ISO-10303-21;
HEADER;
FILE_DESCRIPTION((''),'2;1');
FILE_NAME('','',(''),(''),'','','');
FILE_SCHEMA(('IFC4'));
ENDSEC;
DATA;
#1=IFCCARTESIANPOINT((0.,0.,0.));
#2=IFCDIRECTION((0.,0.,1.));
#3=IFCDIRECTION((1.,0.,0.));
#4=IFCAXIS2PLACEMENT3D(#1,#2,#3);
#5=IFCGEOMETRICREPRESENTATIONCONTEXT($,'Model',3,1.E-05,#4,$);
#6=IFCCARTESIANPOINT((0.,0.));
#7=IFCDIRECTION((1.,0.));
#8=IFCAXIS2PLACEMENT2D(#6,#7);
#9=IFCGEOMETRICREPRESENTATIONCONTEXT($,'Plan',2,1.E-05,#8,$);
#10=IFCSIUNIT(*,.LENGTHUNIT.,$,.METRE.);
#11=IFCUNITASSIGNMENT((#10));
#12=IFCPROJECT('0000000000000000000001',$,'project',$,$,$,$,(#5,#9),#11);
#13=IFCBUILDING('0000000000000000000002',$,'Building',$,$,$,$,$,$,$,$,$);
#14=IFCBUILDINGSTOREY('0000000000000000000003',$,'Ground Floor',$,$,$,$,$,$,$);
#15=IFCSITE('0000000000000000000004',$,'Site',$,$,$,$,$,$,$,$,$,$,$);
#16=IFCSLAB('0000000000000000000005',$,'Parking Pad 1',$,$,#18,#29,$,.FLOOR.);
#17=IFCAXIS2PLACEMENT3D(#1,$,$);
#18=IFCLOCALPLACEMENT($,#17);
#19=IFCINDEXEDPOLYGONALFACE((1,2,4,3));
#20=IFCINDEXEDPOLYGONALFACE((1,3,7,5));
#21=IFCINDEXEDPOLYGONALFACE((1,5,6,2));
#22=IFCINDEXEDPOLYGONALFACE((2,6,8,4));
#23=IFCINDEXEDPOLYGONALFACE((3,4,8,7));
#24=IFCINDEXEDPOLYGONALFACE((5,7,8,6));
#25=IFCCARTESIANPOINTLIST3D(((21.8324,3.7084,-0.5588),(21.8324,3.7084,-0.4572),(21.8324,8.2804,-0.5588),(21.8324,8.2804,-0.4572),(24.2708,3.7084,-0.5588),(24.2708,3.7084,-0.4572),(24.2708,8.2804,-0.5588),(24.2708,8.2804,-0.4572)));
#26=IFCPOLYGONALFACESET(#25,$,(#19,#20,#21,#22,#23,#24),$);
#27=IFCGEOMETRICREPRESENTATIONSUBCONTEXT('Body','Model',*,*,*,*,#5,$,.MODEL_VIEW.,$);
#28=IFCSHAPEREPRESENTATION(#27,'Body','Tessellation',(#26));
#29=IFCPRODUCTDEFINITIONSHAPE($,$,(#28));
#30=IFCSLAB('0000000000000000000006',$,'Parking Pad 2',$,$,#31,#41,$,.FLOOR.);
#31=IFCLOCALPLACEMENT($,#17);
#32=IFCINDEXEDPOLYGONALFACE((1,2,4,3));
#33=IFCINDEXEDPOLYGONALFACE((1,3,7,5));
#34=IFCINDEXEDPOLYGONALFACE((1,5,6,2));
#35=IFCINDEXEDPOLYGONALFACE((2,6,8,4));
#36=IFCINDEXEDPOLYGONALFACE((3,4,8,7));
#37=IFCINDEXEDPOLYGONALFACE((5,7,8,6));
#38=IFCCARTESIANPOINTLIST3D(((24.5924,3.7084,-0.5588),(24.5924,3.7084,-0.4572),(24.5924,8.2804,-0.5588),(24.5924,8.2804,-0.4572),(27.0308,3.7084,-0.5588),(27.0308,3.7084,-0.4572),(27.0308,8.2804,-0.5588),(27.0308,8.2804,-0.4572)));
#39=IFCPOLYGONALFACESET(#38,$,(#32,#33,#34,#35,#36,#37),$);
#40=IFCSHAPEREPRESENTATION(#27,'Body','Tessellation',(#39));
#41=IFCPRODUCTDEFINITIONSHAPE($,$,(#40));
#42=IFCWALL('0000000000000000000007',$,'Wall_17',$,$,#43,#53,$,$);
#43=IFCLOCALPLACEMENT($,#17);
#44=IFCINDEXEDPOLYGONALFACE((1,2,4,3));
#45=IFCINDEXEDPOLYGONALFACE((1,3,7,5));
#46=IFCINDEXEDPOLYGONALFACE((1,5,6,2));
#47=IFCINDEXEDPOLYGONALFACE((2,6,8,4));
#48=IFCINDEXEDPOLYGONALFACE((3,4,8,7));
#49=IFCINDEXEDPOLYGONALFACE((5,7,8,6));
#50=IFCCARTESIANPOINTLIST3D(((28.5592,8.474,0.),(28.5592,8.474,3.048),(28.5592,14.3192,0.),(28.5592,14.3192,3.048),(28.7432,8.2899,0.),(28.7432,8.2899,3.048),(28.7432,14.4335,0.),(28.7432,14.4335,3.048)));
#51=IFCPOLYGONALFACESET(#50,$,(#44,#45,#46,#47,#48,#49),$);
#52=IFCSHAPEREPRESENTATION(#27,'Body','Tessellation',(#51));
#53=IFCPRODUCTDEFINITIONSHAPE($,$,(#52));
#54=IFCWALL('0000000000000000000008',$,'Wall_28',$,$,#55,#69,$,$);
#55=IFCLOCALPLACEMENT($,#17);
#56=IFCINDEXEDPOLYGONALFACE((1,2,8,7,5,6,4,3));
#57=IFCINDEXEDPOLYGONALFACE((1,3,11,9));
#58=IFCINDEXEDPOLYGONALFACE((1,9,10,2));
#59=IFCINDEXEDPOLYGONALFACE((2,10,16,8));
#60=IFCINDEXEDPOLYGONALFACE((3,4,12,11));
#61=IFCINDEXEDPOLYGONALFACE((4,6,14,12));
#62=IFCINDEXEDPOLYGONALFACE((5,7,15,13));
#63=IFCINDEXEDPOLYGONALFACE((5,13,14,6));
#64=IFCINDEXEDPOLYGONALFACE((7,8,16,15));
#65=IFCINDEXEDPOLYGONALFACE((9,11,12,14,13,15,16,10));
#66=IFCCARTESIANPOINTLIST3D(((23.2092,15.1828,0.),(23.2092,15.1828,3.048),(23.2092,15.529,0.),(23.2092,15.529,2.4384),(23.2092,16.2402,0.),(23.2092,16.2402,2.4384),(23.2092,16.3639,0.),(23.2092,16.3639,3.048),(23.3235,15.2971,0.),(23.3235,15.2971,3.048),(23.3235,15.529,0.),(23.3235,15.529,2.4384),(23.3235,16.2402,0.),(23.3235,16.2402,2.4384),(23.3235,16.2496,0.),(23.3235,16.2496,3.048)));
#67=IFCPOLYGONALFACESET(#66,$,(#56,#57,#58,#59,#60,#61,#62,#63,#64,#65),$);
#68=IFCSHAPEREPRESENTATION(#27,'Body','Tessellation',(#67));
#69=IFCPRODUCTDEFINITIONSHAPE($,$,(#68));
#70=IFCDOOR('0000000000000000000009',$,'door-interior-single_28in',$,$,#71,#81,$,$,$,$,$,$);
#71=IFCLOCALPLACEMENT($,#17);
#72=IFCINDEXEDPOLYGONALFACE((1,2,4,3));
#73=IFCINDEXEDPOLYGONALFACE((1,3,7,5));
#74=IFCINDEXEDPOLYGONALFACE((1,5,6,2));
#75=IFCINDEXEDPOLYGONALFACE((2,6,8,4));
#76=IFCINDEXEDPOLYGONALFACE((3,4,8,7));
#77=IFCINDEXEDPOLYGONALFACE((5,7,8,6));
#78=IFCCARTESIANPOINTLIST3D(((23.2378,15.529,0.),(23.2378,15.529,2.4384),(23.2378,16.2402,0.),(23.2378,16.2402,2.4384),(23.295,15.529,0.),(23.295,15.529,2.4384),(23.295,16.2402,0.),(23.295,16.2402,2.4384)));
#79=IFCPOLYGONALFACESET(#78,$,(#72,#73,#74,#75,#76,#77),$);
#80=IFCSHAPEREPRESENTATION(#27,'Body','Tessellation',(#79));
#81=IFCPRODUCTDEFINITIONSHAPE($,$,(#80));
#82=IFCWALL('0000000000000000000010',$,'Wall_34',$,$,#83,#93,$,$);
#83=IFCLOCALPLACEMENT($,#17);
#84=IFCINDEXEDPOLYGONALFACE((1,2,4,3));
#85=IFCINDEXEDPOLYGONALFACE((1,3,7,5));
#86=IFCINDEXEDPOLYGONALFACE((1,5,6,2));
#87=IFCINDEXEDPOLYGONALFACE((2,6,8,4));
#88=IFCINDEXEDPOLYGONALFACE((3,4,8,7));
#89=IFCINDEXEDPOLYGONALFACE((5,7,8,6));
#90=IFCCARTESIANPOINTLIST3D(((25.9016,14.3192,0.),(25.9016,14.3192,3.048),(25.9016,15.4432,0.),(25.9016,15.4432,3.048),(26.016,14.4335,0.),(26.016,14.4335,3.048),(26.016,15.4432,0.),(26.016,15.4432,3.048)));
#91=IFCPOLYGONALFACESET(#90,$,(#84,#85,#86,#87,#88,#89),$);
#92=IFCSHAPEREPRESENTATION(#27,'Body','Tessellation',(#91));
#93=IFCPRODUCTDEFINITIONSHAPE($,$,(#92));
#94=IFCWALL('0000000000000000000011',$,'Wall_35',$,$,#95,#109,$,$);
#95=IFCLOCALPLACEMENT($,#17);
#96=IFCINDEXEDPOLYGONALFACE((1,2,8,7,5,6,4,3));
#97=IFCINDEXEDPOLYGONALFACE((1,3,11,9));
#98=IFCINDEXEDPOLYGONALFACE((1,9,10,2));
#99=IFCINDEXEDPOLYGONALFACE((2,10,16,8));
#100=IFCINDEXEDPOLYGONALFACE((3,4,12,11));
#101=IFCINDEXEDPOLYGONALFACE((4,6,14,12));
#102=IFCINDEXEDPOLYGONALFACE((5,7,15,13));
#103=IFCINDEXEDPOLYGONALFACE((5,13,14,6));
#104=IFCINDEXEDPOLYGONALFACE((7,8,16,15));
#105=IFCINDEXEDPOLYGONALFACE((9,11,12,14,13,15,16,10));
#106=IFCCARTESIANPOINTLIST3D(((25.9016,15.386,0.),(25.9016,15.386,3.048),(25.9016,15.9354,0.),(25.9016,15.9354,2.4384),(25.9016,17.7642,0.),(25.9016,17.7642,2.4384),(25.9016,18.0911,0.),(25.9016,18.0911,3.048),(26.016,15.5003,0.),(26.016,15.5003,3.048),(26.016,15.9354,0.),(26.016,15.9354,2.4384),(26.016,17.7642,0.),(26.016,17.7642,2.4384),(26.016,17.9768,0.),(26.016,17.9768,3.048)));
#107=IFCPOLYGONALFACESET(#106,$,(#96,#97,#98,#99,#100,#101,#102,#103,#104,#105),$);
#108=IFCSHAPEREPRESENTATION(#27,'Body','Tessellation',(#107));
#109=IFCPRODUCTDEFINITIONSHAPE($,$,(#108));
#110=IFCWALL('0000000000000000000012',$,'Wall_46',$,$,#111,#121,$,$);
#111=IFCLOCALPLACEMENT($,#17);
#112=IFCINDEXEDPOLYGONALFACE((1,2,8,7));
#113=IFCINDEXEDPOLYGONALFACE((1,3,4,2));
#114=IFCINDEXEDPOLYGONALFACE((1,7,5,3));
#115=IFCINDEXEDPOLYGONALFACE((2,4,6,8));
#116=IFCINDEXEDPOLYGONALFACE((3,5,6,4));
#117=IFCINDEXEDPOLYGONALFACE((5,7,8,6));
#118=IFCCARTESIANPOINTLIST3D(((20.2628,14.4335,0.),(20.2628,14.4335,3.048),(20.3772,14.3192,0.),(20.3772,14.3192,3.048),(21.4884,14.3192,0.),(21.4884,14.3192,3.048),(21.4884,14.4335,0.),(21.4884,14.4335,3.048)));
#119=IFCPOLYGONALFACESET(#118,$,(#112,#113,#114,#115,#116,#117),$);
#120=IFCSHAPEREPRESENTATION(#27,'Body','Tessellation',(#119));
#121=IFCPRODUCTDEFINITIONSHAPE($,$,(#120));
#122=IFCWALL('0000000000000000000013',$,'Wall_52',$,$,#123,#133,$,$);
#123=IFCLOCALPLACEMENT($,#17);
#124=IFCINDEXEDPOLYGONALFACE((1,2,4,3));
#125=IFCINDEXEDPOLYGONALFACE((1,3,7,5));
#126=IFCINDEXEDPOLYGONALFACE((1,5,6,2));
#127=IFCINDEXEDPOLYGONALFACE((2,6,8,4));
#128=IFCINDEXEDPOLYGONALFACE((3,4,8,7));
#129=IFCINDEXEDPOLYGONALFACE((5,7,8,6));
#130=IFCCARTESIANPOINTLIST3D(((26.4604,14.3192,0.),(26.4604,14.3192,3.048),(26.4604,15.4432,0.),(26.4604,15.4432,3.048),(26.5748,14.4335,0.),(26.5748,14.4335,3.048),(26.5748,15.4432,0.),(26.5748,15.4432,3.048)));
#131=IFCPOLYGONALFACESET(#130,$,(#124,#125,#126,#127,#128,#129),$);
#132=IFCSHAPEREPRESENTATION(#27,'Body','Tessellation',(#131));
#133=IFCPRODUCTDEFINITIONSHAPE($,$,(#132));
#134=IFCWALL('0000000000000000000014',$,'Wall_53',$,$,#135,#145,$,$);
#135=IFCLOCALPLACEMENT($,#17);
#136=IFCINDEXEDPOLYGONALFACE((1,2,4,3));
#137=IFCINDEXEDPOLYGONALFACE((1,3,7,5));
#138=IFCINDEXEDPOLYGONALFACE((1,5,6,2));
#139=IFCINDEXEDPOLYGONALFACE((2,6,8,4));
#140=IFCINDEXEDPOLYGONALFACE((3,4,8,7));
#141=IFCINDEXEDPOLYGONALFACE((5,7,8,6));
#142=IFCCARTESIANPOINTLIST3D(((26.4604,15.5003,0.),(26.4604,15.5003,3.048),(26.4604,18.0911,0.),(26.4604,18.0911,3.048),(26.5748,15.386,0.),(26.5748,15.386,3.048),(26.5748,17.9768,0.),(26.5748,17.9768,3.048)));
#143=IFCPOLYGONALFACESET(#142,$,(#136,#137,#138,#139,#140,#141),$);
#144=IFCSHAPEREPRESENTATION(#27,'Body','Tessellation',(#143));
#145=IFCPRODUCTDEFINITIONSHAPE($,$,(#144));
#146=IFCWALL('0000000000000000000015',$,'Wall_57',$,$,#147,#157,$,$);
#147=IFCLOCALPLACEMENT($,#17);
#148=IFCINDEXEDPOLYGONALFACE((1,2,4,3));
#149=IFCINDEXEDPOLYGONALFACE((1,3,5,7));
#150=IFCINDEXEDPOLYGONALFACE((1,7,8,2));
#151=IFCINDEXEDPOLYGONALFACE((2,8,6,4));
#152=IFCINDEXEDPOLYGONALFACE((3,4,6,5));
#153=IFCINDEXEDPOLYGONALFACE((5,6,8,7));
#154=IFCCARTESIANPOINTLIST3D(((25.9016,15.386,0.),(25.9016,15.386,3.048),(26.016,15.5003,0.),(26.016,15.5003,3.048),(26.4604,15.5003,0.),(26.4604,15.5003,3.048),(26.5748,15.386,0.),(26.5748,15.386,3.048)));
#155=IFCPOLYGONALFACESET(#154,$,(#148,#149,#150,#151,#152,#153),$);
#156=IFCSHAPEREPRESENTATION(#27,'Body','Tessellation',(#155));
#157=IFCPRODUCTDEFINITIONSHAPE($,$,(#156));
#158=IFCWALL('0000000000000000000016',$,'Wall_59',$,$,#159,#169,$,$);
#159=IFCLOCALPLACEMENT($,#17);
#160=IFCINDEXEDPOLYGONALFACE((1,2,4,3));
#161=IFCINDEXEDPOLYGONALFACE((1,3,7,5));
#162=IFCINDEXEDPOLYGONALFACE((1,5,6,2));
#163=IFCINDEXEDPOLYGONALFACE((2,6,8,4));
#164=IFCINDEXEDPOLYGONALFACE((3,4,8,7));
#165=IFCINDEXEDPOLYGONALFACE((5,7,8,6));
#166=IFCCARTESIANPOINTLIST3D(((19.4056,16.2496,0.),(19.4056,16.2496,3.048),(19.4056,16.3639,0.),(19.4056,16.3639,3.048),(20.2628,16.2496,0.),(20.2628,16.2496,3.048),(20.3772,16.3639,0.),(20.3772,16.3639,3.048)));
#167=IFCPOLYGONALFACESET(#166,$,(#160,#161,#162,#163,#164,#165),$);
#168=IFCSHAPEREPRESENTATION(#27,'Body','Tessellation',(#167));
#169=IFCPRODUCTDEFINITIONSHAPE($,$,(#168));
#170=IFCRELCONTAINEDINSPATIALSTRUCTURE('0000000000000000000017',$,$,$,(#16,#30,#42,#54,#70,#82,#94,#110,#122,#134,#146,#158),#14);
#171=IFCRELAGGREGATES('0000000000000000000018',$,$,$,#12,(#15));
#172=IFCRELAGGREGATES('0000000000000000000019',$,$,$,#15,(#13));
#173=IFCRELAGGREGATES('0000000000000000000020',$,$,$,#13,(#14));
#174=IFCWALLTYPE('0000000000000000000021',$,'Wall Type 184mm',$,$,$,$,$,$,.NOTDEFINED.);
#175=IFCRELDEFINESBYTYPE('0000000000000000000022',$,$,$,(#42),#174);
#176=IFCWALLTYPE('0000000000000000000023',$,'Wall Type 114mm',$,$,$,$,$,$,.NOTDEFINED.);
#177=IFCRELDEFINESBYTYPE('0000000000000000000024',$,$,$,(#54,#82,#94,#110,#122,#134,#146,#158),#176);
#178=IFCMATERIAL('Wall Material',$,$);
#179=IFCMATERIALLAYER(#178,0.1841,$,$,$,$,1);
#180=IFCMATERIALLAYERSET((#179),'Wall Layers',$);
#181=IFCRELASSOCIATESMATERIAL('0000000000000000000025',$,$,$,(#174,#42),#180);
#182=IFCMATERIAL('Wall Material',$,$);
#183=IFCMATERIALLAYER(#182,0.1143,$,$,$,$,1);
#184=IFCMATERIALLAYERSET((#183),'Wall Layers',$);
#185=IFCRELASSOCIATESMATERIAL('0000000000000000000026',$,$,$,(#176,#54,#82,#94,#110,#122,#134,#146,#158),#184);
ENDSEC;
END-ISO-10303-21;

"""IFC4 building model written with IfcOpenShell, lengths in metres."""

from ifc_helpers import new_model, si_unit, frame, origin_with_axes, origin_2d_with_axis, place, context, subcontext, project, spatial, line, indexed_curve, rectangle, outline, extrude, material, layer, layer_set, layer_usage, type_object, element, fill, save


model = new_model("IFC4")

# Units and contexts
model_context = context("Model", 3, precision=1e-05, world=origin_with_axes())
plan_context = context("Plan", 2, precision=1e-05, world=origin_2d_with_axis())
body_context = subcontext(model_context, "Body", "Model", "MODEL_VIEW")
ifc_project = project(units=[si_unit("LENGTHUNIT", "METRE")], contexts=[model_context, plan_context])

# Site, building, storey
site = spatial("IfcSite", under=ifc_project, Name="Site")
building = spatial("IfcBuilding", under=site, Name="Building")
storey = spatial("IfcBuildingStorey", under=building, Name="Ground Floor")

# Slabs
for number, where, z_axis, x_axis, name in (
    (1, (23.0516, 5.9944, -0.5588), (0.0, 0.0, 1.0), (-1.0, 0.0, 0.0), "Parking Pad 1"),
    (2, (25.8116, 5.9944, -0.5588), (0.0, 0.0, 1.0), (-1.0, 0.0, 0.0), "Parking Pad 2"),
):
    element("IfcSlab", number, at=place(None, frame(where, z_axis=z_axis, x_axis=x_axis)), inside=storey, Name=name, PredefinedType="FLOOR", context=body_context, shape_type="SweptSolid", body=[
        extrude(rectangle(XDim=2.4384, YDim=4.572), None, (0.0, 0.0, 1.0), 0.1016),
    ])

# Wall
ifc_material_1 = material(Name="Wall Material")
ifc_layer_1 = layer(ifc_material_1, 0.1841, Priority=1)
ifc_layer_set_1 = layer_set([ifc_layer_1], Name="Wall Layers")
ifc_layer_usage_1 = layer_usage(ifc_layer_set_1, "AXIS2", "POSITIVE", -0.0921)
wall_type_1 = type_object("IfcWallType", Name="Wall Type 184mm", PredefinedType="NOTDEFINED", material=ifc_layer_set_1)
wall_1_placement = place(None, frame((28.6512, 14.3764, 0.0), z_axis=(0.0, 0.0, 1.0), x_axis=(0.0, -1.0, 0.0)))
element("IfcWall", 3, at=wall_1_placement, inside=storey, type_object=wall_type_1, material=ifc_layer_usage_1, Name="Wall_17", context=body_context, shape_type="SweptSolid", body=[
    extrude(outline(indexed_curve([(0.0571, -0.0921), (-0.0571, 0.0921), (6.0865, 0.0921), (5.9024, -0.0921)], segments=[line(1, 2, 3, 4, 1)])), origin_with_axes(), (0.0, 0.0, 1.0), 3.048),
])

# Wall, opening, door
ifc_material_2 = material(Name="Wall Material")
ifc_layer_2 = layer(ifc_material_2, 0.1143, Priority=1)
ifc_layer_set_2 = layer_set([ifc_layer_2], Name="Wall Layers")
ifc_layer_usage_2 = layer_usage(ifc_layer_set_2, "AXIS2", "POSITIVE", -0.0571)
wall_type_2 = type_object("IfcWallType", Name="Wall Type 114mm", PredefinedType="NOTDEFINED", material=ifc_layer_set_2)
wall_2_placement = place(None, frame((23.2664, 15.24, 0.0), z_axis=(0.0, 0.0, 1.0), x_axis=(0.0, 1.0, 0.0)))
wall_2 = element("IfcWall", 4, at=wall_2_placement, inside=storey, type_object=wall_type_2, material=ifc_layer_usage_2, Name="Wall_28", context=body_context, shape_type="SweptSolid", body=[
    extrude(outline(indexed_curve([(0.0572, -0.0571), (-0.0572, 0.0571), (1.1239, 0.0571), (1.0096, -0.0571)], segments=[line(1, 2, 3, 4, 1)])), origin_with_axes(), (0.0, 0.0, 1.0), 3.048),
])
opening_1_placement = place(wall_2_placement, frame((0.6446, 0.0, 0.0), z_axis=(0.0, 0.0, 1.0), x_axis=(1.0, 0.0, 0.0)))
opening_1 = element("IfcOpeningElement", 5, at=opening_1_placement, cuts=wall_2, context=body_context, shape_type="SweptSolid", body=[
    extrude(rectangle(XDim=0.7112, YDim=0.5), None, (0.0, 0.0, 1.0), 2.4384),
])
door_1_placement = place(None, frame((23.2664, 15.8846, 0.0), z_axis=(0.0, 0.0, 1.0), x_axis=(0.0, -1.0, 0.0)))
door_1 = element("IfcDoor", 6, at=door_1_placement, inside=storey, Name="door-interior-single_28in", context=body_context, shape_type="SweptSolid", body=[
    extrude(rectangle(XDim=0.7112, YDim=0.0571), None, (0.0, 0.0, 1.0), 2.4384),
])
fill(opening_1, door_1)

# Wall
ifc_layer_usage_3 = layer_usage(ifc_layer_set_2, "AXIS2", "POSITIVE", -0.0571)
wall_3_placement = place(None, frame((25.9588, 14.3764, 0.0), z_axis=(0.0, 0.0, 1.0), x_axis=(0.0, 1.0, 0.0)))
element("IfcWall", 7, at=wall_3_placement, inside=storey, type_object=wall_type_2, material=ifc_layer_usage_3, Name="Wall_34", context=body_context, shape_type="SweptSolid", body=[
    extrude(outline(indexed_curve([(0.0572, -0.0571), (-0.0572, 0.0571), (1.0668, 0.0571), (1.0668, -0.0571)], segments=[line(1, 2, 3, 4, 1)])), origin_with_axes(), (0.0, 0.0, 1.0), 3.048),
])

# Wall, opening
ifc_layer_usage_4 = layer_usage(ifc_layer_set_2, "AXIS2", "POSITIVE", -0.0571)
wall_4_placement = place(None, frame((25.9588, 15.4432, 0.0), z_axis=(0.0, 0.0, 1.0), x_axis=(0.0, 1.0, 0.0)))
wall_4 = element("IfcWall", 8, at=wall_4_placement, inside=storey, type_object=wall_type_2, material=ifc_layer_usage_4, Name="Wall_35", context=body_context, shape_type="SweptSolid", body=[
    extrude(outline(indexed_curve([(0.0572, -0.0571), (-0.0572, 0.0571), (2.6479, 0.0571), (2.5336, -0.0571)], segments=[line(1, 2, 3, 4, 1)])), origin_with_axes(), (0.0, 0.0, 1.0), 3.048),
])
opening_2_placement = place(wall_4_placement, frame((1.4066, 0.0, 0.0), z_axis=(0.0, 0.0, 1.0), x_axis=(1.0, 0.0, 0.0)))
element("IfcOpeningElement", 9, at=opening_2_placement, cuts=wall_4, context=body_context, shape_type="SweptSolid", body=[
    extrude(rectangle(XDim=1.8288, YDim=0.5), None, (0.0, 0.0, 1.0), 2.4384),
])

# Walls
ifc_layer_usage_5 = layer_usage(ifc_layer_set_2, "AXIS2", "POSITIVE", -0.0571)
wall_5_placement = place(None, frame((21.4884, 14.3764, 0.0), z_axis=(0.0, 0.0, 1.0), x_axis=(-1.0, 0.0, 0.0)))
element("IfcWall", 10, at=wall_5_placement, inside=storey, type_object=wall_type_2, material=ifc_layer_usage_5, Name="Wall_46", context=body_context, shape_type="SweptSolid", body=[
    extrude(outline(indexed_curve([(0.0, -0.0571), (0.0, 0.0571), (1.1112, 0.0571), (1.2255, -0.0571)], segments=[line(1, 2, 3, 4, 1)])), origin_with_axes(), (0.0, 0.0, 1.0), 3.048),
])
ifc_layer_usage_6 = layer_usage(ifc_layer_set_2, "AXIS2", "POSITIVE", -0.0571)
wall_6_placement = place(None, frame((26.5176, 14.3764, 0.0), z_axis=(0.0, 0.0, 1.0), x_axis=(0.0, 1.0, 0.0)))
element("IfcWall", 11, at=wall_6_placement, inside=storey, type_object=wall_type_2, material=ifc_layer_usage_6, Name="Wall_52", context=body_context, shape_type="SweptSolid", body=[
    extrude(outline(indexed_curve([(0.0572, -0.0571), (-0.0572, 0.0571), (1.0668, 0.0571), (1.0668, -0.0571)], segments=[line(1, 2, 3, 4, 1)])), origin_with_axes(), (0.0, 0.0, 1.0), 3.048),
])
ifc_layer_usage_7 = layer_usage(ifc_layer_set_2, "AXIS2", "POSITIVE", -0.0571)
wall_7_placement = place(None, frame((26.5176, 15.4432, 0.0), z_axis=(0.0, 0.0, 1.0), x_axis=(0.0, 1.0, 0.0)))
element("IfcWall", 12, at=wall_7_placement, inside=storey, type_object=wall_type_2, material=ifc_layer_usage_7, Name="Wall_53", context=body_context, shape_type="SweptSolid", body=[
    extrude(outline(indexed_curve([(-0.0571, -0.0571), (0.0571, 0.0571), (2.6479, 0.0571), (2.5336, -0.0571)], segments=[line(1, 2, 3, 4, 1)])), origin_with_axes(), (0.0, 0.0, 1.0), 3.048),
])
ifc_layer_usage_8 = layer_usage(ifc_layer_set_2, "AXIS2", "POSITIVE", -0.0571)
wall_8_placement = place(None, frame((25.9588, 15.4432, 0.0), z_axis=(0.0, 0.0, 1.0), x_axis=(1.0, 0.0, 0.0)))
element("IfcWall", 13, at=wall_8_placement, inside=storey, type_object=wall_type_2, material=ifc_layer_usage_8, Name="Wall_57", context=body_context, shape_type="SweptSolid", body=[
    extrude(outline(indexed_curve([(-0.0572, -0.0571), (0.0572, 0.0571), (0.5016, 0.0571), (0.6159, -0.0571)], segments=[line(1, 2, 3, 4, 1)])), origin_with_axes(), (0.0, 0.0, 1.0), 3.048),
])
ifc_layer_usage_9 = layer_usage(ifc_layer_set_2, "AXIS2", "POSITIVE", -0.0571)
wall_9_placement = place(None, frame((20.32, 16.3068, 0.0), z_axis=(0.0, 0.0, 1.0), x_axis=(-1.0, 0.0, 0.0)))
element("IfcWall", 14, at=wall_9_placement, inside=storey, type_object=wall_type_2, material=ifc_layer_usage_9, Name="Wall_59", context=body_context, shape_type="SweptSolid", body=[
    extrude(outline(indexed_curve([(-0.0571, -0.0571), (0.0571, 0.0571), (0.9144, 0.0571), (0.9144, -0.0571)], segments=[line(1, 2, 3, 4, 1)])), origin_with_axes(), (0.0, 0.0, 1.0), 3.048),
])

save(model, "model.ifc")
